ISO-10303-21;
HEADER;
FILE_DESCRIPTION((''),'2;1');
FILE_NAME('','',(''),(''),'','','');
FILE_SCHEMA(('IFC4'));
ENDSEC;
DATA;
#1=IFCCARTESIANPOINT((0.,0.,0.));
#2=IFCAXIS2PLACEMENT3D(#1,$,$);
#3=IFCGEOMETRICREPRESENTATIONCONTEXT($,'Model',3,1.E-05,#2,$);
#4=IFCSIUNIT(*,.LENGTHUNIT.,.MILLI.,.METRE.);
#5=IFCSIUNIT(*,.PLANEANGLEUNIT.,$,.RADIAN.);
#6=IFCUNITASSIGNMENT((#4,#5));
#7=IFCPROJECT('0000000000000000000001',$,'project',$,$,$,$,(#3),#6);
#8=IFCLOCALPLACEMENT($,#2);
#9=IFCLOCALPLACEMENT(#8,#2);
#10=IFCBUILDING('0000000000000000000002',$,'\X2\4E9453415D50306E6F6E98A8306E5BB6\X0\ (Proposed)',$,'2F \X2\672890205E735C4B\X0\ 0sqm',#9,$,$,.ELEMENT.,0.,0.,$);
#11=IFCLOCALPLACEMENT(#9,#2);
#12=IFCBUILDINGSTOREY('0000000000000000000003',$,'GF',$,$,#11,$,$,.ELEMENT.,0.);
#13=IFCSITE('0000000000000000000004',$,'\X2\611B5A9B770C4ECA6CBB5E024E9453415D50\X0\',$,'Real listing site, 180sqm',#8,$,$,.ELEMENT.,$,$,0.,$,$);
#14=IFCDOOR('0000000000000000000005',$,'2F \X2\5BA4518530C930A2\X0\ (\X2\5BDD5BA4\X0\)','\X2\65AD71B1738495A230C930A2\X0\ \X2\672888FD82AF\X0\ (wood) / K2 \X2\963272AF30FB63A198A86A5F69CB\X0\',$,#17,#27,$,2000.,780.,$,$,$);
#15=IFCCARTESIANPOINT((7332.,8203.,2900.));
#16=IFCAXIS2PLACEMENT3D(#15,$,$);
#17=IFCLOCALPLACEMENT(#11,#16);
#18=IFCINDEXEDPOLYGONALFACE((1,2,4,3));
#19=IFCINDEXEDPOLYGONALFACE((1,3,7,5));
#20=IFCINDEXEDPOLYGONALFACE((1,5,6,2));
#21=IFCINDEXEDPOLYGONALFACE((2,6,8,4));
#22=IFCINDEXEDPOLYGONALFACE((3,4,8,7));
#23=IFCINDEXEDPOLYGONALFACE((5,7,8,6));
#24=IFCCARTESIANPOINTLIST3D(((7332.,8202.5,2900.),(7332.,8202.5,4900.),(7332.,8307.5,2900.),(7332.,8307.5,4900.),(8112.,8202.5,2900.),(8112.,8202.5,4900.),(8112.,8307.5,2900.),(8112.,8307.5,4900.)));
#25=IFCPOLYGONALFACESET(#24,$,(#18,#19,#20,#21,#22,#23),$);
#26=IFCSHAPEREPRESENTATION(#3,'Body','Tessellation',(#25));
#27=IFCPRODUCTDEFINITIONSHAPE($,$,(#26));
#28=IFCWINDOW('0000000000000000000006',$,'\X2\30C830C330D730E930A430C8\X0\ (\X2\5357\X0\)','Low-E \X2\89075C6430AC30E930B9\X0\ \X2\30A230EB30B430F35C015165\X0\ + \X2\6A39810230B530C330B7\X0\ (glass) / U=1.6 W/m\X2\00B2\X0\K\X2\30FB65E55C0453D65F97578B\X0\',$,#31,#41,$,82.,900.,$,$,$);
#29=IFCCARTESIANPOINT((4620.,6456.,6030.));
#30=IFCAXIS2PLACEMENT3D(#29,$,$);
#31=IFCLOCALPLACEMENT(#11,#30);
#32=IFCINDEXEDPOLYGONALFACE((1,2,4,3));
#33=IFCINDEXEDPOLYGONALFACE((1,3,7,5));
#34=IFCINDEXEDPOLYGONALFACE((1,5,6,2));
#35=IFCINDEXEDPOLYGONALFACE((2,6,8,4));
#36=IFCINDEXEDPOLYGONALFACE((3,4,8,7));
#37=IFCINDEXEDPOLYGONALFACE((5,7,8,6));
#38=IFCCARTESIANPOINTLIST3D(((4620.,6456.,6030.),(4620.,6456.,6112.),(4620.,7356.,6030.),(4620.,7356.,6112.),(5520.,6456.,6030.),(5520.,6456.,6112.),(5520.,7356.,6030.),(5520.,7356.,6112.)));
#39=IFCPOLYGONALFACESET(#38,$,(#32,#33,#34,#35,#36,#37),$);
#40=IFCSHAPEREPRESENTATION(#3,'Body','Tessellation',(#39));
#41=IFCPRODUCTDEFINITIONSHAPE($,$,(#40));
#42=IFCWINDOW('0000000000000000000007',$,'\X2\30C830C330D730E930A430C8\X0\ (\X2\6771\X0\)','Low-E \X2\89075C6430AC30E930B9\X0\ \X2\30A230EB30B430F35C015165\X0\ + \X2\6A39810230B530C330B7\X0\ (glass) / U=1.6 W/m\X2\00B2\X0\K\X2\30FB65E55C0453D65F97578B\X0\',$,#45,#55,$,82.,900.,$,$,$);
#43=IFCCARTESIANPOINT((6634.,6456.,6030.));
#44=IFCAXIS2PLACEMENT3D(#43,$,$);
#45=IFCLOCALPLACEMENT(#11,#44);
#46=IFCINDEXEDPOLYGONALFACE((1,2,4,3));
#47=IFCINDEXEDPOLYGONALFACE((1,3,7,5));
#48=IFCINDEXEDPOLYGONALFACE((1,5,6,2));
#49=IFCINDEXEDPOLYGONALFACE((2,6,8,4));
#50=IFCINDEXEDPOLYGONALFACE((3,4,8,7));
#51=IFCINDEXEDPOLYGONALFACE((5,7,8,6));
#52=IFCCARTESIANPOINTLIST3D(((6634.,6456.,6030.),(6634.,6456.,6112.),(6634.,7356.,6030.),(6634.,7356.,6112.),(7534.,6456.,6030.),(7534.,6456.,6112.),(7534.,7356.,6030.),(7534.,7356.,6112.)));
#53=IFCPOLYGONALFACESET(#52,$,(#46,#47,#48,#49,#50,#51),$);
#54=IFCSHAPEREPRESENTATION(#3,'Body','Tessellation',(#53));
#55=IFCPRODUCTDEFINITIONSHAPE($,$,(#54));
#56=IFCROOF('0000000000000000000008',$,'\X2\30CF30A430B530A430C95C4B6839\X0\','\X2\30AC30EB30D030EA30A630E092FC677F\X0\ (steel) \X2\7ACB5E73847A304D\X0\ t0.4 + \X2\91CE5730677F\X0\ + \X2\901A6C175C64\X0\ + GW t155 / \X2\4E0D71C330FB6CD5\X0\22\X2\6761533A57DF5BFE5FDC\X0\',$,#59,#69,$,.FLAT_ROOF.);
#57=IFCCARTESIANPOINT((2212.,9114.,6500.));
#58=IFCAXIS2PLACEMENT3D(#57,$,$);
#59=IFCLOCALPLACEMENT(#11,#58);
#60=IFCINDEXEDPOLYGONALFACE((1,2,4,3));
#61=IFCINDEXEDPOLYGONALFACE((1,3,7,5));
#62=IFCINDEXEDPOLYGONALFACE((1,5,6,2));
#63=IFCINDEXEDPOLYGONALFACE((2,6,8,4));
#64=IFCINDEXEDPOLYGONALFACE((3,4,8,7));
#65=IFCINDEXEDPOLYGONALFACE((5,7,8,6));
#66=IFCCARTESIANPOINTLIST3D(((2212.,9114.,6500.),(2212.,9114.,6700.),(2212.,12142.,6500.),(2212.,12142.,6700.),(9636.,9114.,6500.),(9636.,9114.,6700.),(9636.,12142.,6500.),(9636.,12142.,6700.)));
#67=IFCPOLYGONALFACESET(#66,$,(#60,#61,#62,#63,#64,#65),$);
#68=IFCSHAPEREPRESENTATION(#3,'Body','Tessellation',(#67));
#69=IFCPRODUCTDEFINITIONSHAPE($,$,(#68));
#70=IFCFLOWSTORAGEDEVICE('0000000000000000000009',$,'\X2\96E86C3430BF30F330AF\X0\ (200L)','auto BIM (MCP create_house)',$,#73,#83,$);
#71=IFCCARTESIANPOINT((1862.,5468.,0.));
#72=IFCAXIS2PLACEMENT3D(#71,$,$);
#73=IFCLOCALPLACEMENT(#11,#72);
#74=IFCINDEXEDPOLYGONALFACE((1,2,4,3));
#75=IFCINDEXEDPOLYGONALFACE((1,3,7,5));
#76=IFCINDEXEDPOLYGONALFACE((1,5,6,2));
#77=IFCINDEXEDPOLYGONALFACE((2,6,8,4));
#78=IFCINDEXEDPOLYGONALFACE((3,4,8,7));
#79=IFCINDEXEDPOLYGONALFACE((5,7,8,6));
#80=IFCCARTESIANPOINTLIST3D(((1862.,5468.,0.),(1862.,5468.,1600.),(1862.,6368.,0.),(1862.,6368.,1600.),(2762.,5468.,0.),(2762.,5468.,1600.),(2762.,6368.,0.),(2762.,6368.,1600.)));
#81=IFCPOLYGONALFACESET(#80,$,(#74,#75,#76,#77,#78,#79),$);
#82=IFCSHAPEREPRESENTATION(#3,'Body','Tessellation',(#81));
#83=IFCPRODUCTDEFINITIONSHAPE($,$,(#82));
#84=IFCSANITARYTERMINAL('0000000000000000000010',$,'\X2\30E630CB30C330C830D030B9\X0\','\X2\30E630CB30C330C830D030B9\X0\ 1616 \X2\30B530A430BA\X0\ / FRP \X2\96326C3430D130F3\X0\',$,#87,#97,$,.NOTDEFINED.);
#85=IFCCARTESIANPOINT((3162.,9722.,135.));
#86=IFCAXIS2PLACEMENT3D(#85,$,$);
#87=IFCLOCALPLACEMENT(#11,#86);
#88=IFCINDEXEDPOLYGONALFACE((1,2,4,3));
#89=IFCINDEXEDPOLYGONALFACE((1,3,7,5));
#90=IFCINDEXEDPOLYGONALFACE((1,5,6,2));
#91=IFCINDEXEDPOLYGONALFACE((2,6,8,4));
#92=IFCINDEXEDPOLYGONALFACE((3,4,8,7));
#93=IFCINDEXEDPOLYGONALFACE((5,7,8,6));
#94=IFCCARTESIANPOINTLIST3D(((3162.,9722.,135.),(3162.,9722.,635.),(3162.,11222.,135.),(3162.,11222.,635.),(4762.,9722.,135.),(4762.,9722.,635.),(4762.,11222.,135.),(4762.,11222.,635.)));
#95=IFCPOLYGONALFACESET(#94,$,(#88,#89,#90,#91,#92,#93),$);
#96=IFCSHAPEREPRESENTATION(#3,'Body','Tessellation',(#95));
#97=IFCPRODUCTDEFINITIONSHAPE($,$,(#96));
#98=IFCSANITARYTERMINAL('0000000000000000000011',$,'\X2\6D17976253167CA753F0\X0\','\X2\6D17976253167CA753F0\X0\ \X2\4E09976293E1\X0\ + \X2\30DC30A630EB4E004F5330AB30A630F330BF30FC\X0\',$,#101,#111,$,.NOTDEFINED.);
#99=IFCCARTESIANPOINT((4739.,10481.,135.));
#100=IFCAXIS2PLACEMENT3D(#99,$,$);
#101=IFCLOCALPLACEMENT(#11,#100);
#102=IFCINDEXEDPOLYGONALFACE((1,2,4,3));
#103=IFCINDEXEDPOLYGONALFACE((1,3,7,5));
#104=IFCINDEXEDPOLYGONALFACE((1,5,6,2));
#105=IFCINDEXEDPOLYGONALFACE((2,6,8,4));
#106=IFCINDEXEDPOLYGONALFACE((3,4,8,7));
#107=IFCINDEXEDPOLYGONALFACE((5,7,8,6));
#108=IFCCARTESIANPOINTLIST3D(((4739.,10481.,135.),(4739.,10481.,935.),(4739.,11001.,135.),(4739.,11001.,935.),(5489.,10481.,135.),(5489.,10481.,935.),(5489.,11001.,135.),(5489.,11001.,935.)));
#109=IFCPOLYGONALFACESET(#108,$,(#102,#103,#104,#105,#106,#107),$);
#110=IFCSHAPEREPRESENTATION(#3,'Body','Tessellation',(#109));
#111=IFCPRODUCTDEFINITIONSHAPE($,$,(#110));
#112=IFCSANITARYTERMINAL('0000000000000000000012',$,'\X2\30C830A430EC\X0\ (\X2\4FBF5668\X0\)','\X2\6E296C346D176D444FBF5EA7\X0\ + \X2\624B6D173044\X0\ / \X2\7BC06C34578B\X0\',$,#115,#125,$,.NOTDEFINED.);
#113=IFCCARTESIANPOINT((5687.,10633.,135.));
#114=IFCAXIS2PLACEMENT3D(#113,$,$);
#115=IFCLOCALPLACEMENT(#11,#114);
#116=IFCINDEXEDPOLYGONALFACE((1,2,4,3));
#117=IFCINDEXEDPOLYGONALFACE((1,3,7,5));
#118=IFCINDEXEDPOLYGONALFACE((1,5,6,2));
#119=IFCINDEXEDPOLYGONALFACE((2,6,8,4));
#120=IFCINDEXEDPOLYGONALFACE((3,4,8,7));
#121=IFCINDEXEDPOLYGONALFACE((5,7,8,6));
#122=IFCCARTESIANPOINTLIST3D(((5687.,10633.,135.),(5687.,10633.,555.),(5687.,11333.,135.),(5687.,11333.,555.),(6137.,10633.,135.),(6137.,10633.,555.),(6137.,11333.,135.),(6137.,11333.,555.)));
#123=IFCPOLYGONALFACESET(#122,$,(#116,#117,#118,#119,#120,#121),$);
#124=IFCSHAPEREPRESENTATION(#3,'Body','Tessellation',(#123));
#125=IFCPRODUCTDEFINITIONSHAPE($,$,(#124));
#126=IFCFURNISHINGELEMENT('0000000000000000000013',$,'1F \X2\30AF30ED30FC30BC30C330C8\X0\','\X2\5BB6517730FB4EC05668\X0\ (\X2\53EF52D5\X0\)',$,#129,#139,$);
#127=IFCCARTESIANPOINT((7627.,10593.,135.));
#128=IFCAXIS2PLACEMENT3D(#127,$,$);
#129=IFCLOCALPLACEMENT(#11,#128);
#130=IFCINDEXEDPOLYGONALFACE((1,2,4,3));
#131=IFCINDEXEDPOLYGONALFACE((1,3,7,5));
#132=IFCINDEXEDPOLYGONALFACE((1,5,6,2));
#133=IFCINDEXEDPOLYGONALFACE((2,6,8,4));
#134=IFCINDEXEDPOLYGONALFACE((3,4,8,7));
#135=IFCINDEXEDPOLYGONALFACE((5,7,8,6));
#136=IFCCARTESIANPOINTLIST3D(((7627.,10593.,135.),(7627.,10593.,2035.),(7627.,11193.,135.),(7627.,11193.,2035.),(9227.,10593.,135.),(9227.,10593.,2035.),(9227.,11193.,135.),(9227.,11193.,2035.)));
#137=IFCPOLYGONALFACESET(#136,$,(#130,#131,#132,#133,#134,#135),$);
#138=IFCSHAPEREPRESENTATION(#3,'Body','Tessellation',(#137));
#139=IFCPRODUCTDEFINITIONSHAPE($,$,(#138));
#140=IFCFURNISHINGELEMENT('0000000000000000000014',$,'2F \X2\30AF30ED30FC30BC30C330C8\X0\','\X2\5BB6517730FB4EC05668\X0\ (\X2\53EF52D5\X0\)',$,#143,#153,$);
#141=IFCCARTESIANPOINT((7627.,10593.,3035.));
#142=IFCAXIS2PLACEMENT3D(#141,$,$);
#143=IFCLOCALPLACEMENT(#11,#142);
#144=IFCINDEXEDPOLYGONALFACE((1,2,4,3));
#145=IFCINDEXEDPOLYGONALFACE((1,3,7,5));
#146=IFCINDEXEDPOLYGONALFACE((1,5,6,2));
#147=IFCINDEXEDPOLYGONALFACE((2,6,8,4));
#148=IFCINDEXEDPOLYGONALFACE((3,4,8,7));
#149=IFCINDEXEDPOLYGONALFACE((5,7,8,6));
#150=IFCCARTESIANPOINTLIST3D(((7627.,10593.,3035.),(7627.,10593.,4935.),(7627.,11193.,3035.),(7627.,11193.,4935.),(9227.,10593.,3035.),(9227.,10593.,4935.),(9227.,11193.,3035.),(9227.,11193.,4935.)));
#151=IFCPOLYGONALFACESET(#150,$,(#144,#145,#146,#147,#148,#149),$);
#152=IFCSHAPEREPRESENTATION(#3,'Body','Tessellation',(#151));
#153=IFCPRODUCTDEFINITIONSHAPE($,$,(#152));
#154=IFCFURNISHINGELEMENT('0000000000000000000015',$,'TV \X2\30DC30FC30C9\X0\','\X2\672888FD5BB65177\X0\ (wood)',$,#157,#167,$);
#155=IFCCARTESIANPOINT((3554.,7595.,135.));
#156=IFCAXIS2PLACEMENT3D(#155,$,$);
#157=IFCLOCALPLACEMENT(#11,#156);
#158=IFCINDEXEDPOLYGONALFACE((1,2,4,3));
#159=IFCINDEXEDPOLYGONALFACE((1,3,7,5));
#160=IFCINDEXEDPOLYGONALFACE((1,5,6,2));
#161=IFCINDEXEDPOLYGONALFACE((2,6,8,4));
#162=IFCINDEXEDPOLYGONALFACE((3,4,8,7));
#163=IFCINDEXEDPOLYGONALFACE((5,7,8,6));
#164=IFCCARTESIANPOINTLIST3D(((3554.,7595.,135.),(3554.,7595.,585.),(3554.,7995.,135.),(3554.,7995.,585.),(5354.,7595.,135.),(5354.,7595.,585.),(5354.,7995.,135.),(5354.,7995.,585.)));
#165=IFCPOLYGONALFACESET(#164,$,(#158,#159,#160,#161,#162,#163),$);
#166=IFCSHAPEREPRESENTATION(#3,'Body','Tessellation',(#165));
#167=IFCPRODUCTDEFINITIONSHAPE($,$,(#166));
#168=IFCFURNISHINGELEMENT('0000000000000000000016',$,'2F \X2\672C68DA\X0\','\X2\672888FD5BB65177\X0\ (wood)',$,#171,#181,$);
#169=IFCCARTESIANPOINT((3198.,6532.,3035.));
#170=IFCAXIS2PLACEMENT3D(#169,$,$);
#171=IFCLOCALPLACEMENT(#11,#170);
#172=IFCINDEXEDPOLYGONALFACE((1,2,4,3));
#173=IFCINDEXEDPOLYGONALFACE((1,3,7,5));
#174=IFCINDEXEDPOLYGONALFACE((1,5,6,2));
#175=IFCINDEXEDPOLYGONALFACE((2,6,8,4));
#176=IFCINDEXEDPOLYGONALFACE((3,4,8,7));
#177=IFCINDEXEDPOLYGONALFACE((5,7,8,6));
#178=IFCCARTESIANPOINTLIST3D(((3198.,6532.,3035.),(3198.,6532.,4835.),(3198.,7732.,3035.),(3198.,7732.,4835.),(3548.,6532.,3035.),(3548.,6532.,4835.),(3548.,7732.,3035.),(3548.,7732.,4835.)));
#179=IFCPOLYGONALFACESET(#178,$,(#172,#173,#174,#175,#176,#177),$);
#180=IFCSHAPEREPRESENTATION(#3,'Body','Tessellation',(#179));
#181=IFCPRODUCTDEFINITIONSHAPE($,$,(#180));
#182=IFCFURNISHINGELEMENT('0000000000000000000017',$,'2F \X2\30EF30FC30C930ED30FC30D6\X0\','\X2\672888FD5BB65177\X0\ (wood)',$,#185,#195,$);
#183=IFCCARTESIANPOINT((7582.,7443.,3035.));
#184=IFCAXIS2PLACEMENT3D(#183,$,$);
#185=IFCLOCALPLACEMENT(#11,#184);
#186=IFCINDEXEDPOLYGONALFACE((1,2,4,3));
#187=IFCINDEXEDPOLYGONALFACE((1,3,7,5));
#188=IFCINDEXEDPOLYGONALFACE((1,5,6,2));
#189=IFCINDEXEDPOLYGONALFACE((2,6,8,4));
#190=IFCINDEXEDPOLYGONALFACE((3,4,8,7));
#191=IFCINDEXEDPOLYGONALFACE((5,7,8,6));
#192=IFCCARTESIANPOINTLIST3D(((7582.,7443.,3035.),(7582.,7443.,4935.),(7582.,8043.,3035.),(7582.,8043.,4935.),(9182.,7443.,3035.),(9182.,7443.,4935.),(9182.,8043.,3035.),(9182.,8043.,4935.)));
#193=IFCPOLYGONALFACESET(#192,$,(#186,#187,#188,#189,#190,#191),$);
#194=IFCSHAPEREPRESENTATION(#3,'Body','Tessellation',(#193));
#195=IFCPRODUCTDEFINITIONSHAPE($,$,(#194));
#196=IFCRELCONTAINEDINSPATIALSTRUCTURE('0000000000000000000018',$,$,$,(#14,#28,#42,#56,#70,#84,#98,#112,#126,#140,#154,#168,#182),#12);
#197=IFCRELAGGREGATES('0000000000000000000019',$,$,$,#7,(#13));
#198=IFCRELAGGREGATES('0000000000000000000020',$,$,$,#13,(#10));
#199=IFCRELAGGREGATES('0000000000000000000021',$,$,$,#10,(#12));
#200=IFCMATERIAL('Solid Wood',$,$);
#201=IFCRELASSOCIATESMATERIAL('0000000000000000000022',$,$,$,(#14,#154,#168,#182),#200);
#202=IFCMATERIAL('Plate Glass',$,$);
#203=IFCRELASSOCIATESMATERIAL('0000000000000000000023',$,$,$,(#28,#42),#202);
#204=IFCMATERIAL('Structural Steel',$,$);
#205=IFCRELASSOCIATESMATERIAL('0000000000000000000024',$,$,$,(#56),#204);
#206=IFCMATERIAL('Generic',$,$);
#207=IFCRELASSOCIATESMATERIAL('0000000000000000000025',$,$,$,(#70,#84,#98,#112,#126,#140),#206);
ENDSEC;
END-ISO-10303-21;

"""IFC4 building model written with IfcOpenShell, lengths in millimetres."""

from ifc_helpers import new_model, si_unit, frame, frame_2d, origin, place, context, project, spatial, rectangle, extrude, material, element, save


model = new_model("IFC4")

# Units and contexts
model_context = context("Model", 3, precision=1e-05, world=origin())
ifc_project = project(units=[si_unit("LENGTHUNIT", "METRE", prefix="MILLI"), si_unit("PLANEANGLEUNIT", "RADIAN")], contexts=[model_context])

# Site, building, storey
site_placement = place(None, origin())
site = spatial("IfcSite", under=ifc_project, at=site_placement, Name="愛媛県今治市五十嵐", ObjectType="Real listing site, 180sqm", CompositionType="ELEMENT", RefElevation=0.0)
building_placement = place(site_placement, origin())
building = spatial("IfcBuilding", under=site, at=building_placement, Name="五十嵐の潮風の家 (Proposed)", ObjectType="2F 木造平屋 0sqm", CompositionType="ELEMENT", ElevationOfRefHeight=0.0, ElevationOfTerrain=0.0)
storey_placement = place(building_placement, origin())
storey = spatial("IfcBuildingStorey", under=building, at=storey_placement, Name="GF", CompositionType="ELEMENT", Elevation=0.0)

# Shared definitions
ifc_material_1 = material(Name="Solid Wood")
ifc_material_2 = material(Name="Plate Glass")

# Door
door_1_placement = place(storey_placement, frame((7332.0, 8203.0, 2900.0)))
element("IfcDoor", 1, at=door_1_placement, inside=storey, material=ifc_material_1, Name="2F 室内ドア (寝室)", Description="断熱玄関ドア 木製芯 (wood) / K2 防犯・採風機構", OverallHeight=2000.0, OverallWidth=780.0, context=model_context, shape_type="SweptSolid", body=[
    extrude(rectangle(XDim=780.0, YDim=105.0, at=frame_2d((390.0, 52.0))), frame((7332.0, 8203.0, 2900.0)), (0.0, 0.0, 1.0), 2000.0),
])

# Windows
window_1_placement = place(storey_placement, frame((4620.0, 6456.0, 6030.0)))
element("IfcWindow", 2, at=window_1_placement, inside=storey, material=ifc_material_2, Name="トップライト (南)", Description="Low-E 複層ガラス アルゴン封入 + 樹脂サッシ (glass) / U=1.6 W/m²K・日射取得型", OverallHeight=82.0, OverallWidth=900.0, context=model_context, shape_type="SweptSolid", body=[
    extrude(rectangle(XDim=900.0, YDim=900.0, at=frame_2d((450.0, 450.0))), frame((4620.0, 6456.0, 6030.0)), (0.0, 0.0, 1.0), 82.0),
])
window_2_placement = place(storey_placement, frame((6634.0, 6456.0, 6030.0)))
element("IfcWindow", 3, at=window_2_placement, inside=storey, material=ifc_material_2, Name="トップライト (東)", Description="Low-E 複層ガラス アルゴン封入 + 樹脂サッシ (glass) / U=1.6 W/m²K・日射取得型", OverallHeight=82.0, OverallWidth=900.0, context=model_context, shape_type="SweptSolid", body=[
    extrude(rectangle(XDim=900.0, YDim=900.0, at=frame_2d((450.0, 450.0))), frame((6634.0, 6456.0, 6030.0)), (0.0, 0.0, 1.0), 82.0),
])

# Roof
ifc_material_3 = material(Name="Structural Steel")
roof_placement = place(storey_placement, frame((2212.0, 9114.0, 6500.0)))
element("IfcRoof", 4, at=roof_placement, inside=storey, material=ifc_material_3, Name="ハイサイド屋根", Description="ガルバリウム鋼板 (steel) 立平葺き t0.4 + 野地板 + 通気層 + GW t155 / 不燃・法22条区域対応", PredefinedType="FLAT_ROOF", context=model_context, shape_type="SweptSolid", body=[
    extrude(rectangle(XDim=7424.0, YDim=3028.0, at=frame_2d((3712.0, 1514.0))), frame((2212.0, 9114.0, 6500.0)), (0.0, 0.0, 1.0), 200.0),
])

# Flow storage device
ifc_material_4 = material(Name="Generic")
flow_storage_device_placement = place(storey_placement, frame((1862.0, 5468.0, 0.0)))
element("IfcFlowStorageDevice", 5, at=flow_storage_device_placement, inside=storey, material=ifc_material_4, Name="雨水タンク (200L)", Description="auto BIM (MCP create_house)", context=model_context, shape_type="SweptSolid", body=[
    extrude(rectangle(XDim=900.0, YDim=900.0, at=frame_2d((450.0, 450.0))), frame((1862.0, 5468.0, 0.0)), (0.0, 0.0, 1.0), 1600.0),
])

# Sanitary terminals
sanitary_terminal_1_placement = place(storey_placement, frame((3162.0, 9722.0, 135.0)))
element("IfcSanitaryTerminal", 6, at=sanitary_terminal_1_placement, inside=storey, material=ifc_material_4, Name="ユニットバス", Description="ユニットバス 1616 サイズ / FRP 防水パン", PredefinedType="NOTDEFINED", context=model_context, shape_type="SweptSolid", body=[
    extrude(rectangle(XDim=1600.0, YDim=1500.0, at=frame_2d((800.0, 750.0))), frame((3162.0, 9722.0, 135.0)), (0.0, 0.0, 1.0), 500.0),
])
sanitary_terminal_2_placement = place(storey_placement, frame((4739.0, 10481.0, 135.0)))
element("IfcSanitaryTerminal", 7, at=sanitary_terminal_2_placement, inside=storey, material=ifc_material_4, Name="洗面化粧台", Description="洗面化粧台 三面鏡 + ボウル一体カウンター", PredefinedType="NOTDEFINED", context=model_context, shape_type="SweptSolid", body=[
    extrude(rectangle(XDim=750.0, YDim=520.0, at=frame_2d((375.0, 260.0))), frame((4739.0, 10481.0, 135.0)), (0.0, 0.0, 1.0), 800.0),
])
sanitary_terminal_3_placement = place(storey_placement, frame((5687.0, 10633.0, 135.0)))
element("IfcSanitaryTerminal", 8, at=sanitary_terminal_3_placement, inside=storey, material=ifc_material_4, Name="トイレ (便器)", Description="温水洗浄便座 + 手洗い / 節水型", PredefinedType="NOTDEFINED", context=model_context, shape_type="SweptSolid", body=[
    extrude(rectangle(XDim=450.0, YDim=700.0, at=frame_2d((225.0, 350.0))), frame((5687.0, 10633.0, 135.0)), (0.0, 0.0, 1.0), 420.0),
])

# Furnishing elements
furnishing_1_placement = place(storey_placement, frame((7627.0, 10593.0, 135.0)))
element("IfcFurnishingElement", 9, at=furnishing_1_placement, inside=storey, material=ifc_material_4, Name="1F クローゼット", Description="家具・什器 (可動)", context=model_context, shape_type="SweptSolid", body=[
    extrude(rectangle(XDim=1600.0, YDim=600.0, at=frame_2d((800.0, 300.0))), frame((7627.0, 10593.0, 135.0)), (0.0, 0.0, 1.0), 1900.0),
])
furnishing_2_placement = place(storey_placement, frame((7627.0, 10593.0, 3035.0)))
element("IfcFurnishingElement", 10, at=furnishing_2_placement, inside=storey, material=ifc_material_4, Name="2F クローゼット", Description="家具・什器 (可動)", context=model_context, shape_type="SweptSolid", body=[
    extrude(rectangle(XDim=1600.0, YDim=600.0, at=frame_2d((800.0, 300.0))), frame((7627.0, 10593.0, 3035.0)), (0.0, 0.0, 1.0), 1900.0),
])
furnishing_3_placement = place(storey_placement, frame((3554.0, 7595.0, 135.0)))
element("IfcFurnishingElement", 11, at=furnishing_3_placement, inside=storey, material=ifc_material_1, Name="TV ボード", Description="木製家具 (wood)", context=model_context, shape_type="SweptSolid", body=[
    extrude(rectangle(XDim=1800.0, YDim=400.0, at=frame_2d((900.0, 200.0))), frame((3554.0, 7595.0, 135.0)), (0.0, 0.0, 1.0), 450.0),
])
furnishing_4_placement = place(storey_placement, frame((3198.0, 6532.0, 3035.0)))
element("IfcFurnishingElement", 12, at=furnishing_4_placement, inside=storey, material=ifc_material_1, Name="2F 本棚", Description="木製家具 (wood)", context=model_context, shape_type="SweptSolid", body=[
    extrude(rectangle(XDim=350.0, YDim=1200.0, at=frame_2d((175.0, 600.0))), frame((3198.0, 6532.0, 3035.0)), (0.0, 0.0, 1.0), 1800.0),
])
furnishing_5_placement = place(storey_placement, frame((7582.0, 7443.0, 3035.0)))
element("IfcFurnishingElement", 13, at=furnishing_5_placement, inside=storey, material=ifc_material_1, Name="2F ワードローブ", Description="木製家具 (wood)", context=model_context, shape_type="SweptSolid", body=[
    extrude(rectangle(XDim=1600.0, YDim=600.0, at=frame_2d((800.0, 300.0))), frame((7582.0, 7443.0, 3035.0)), (0.0, 0.0, 1.0), 1900.0),
])

save(model, "model.ifc")
